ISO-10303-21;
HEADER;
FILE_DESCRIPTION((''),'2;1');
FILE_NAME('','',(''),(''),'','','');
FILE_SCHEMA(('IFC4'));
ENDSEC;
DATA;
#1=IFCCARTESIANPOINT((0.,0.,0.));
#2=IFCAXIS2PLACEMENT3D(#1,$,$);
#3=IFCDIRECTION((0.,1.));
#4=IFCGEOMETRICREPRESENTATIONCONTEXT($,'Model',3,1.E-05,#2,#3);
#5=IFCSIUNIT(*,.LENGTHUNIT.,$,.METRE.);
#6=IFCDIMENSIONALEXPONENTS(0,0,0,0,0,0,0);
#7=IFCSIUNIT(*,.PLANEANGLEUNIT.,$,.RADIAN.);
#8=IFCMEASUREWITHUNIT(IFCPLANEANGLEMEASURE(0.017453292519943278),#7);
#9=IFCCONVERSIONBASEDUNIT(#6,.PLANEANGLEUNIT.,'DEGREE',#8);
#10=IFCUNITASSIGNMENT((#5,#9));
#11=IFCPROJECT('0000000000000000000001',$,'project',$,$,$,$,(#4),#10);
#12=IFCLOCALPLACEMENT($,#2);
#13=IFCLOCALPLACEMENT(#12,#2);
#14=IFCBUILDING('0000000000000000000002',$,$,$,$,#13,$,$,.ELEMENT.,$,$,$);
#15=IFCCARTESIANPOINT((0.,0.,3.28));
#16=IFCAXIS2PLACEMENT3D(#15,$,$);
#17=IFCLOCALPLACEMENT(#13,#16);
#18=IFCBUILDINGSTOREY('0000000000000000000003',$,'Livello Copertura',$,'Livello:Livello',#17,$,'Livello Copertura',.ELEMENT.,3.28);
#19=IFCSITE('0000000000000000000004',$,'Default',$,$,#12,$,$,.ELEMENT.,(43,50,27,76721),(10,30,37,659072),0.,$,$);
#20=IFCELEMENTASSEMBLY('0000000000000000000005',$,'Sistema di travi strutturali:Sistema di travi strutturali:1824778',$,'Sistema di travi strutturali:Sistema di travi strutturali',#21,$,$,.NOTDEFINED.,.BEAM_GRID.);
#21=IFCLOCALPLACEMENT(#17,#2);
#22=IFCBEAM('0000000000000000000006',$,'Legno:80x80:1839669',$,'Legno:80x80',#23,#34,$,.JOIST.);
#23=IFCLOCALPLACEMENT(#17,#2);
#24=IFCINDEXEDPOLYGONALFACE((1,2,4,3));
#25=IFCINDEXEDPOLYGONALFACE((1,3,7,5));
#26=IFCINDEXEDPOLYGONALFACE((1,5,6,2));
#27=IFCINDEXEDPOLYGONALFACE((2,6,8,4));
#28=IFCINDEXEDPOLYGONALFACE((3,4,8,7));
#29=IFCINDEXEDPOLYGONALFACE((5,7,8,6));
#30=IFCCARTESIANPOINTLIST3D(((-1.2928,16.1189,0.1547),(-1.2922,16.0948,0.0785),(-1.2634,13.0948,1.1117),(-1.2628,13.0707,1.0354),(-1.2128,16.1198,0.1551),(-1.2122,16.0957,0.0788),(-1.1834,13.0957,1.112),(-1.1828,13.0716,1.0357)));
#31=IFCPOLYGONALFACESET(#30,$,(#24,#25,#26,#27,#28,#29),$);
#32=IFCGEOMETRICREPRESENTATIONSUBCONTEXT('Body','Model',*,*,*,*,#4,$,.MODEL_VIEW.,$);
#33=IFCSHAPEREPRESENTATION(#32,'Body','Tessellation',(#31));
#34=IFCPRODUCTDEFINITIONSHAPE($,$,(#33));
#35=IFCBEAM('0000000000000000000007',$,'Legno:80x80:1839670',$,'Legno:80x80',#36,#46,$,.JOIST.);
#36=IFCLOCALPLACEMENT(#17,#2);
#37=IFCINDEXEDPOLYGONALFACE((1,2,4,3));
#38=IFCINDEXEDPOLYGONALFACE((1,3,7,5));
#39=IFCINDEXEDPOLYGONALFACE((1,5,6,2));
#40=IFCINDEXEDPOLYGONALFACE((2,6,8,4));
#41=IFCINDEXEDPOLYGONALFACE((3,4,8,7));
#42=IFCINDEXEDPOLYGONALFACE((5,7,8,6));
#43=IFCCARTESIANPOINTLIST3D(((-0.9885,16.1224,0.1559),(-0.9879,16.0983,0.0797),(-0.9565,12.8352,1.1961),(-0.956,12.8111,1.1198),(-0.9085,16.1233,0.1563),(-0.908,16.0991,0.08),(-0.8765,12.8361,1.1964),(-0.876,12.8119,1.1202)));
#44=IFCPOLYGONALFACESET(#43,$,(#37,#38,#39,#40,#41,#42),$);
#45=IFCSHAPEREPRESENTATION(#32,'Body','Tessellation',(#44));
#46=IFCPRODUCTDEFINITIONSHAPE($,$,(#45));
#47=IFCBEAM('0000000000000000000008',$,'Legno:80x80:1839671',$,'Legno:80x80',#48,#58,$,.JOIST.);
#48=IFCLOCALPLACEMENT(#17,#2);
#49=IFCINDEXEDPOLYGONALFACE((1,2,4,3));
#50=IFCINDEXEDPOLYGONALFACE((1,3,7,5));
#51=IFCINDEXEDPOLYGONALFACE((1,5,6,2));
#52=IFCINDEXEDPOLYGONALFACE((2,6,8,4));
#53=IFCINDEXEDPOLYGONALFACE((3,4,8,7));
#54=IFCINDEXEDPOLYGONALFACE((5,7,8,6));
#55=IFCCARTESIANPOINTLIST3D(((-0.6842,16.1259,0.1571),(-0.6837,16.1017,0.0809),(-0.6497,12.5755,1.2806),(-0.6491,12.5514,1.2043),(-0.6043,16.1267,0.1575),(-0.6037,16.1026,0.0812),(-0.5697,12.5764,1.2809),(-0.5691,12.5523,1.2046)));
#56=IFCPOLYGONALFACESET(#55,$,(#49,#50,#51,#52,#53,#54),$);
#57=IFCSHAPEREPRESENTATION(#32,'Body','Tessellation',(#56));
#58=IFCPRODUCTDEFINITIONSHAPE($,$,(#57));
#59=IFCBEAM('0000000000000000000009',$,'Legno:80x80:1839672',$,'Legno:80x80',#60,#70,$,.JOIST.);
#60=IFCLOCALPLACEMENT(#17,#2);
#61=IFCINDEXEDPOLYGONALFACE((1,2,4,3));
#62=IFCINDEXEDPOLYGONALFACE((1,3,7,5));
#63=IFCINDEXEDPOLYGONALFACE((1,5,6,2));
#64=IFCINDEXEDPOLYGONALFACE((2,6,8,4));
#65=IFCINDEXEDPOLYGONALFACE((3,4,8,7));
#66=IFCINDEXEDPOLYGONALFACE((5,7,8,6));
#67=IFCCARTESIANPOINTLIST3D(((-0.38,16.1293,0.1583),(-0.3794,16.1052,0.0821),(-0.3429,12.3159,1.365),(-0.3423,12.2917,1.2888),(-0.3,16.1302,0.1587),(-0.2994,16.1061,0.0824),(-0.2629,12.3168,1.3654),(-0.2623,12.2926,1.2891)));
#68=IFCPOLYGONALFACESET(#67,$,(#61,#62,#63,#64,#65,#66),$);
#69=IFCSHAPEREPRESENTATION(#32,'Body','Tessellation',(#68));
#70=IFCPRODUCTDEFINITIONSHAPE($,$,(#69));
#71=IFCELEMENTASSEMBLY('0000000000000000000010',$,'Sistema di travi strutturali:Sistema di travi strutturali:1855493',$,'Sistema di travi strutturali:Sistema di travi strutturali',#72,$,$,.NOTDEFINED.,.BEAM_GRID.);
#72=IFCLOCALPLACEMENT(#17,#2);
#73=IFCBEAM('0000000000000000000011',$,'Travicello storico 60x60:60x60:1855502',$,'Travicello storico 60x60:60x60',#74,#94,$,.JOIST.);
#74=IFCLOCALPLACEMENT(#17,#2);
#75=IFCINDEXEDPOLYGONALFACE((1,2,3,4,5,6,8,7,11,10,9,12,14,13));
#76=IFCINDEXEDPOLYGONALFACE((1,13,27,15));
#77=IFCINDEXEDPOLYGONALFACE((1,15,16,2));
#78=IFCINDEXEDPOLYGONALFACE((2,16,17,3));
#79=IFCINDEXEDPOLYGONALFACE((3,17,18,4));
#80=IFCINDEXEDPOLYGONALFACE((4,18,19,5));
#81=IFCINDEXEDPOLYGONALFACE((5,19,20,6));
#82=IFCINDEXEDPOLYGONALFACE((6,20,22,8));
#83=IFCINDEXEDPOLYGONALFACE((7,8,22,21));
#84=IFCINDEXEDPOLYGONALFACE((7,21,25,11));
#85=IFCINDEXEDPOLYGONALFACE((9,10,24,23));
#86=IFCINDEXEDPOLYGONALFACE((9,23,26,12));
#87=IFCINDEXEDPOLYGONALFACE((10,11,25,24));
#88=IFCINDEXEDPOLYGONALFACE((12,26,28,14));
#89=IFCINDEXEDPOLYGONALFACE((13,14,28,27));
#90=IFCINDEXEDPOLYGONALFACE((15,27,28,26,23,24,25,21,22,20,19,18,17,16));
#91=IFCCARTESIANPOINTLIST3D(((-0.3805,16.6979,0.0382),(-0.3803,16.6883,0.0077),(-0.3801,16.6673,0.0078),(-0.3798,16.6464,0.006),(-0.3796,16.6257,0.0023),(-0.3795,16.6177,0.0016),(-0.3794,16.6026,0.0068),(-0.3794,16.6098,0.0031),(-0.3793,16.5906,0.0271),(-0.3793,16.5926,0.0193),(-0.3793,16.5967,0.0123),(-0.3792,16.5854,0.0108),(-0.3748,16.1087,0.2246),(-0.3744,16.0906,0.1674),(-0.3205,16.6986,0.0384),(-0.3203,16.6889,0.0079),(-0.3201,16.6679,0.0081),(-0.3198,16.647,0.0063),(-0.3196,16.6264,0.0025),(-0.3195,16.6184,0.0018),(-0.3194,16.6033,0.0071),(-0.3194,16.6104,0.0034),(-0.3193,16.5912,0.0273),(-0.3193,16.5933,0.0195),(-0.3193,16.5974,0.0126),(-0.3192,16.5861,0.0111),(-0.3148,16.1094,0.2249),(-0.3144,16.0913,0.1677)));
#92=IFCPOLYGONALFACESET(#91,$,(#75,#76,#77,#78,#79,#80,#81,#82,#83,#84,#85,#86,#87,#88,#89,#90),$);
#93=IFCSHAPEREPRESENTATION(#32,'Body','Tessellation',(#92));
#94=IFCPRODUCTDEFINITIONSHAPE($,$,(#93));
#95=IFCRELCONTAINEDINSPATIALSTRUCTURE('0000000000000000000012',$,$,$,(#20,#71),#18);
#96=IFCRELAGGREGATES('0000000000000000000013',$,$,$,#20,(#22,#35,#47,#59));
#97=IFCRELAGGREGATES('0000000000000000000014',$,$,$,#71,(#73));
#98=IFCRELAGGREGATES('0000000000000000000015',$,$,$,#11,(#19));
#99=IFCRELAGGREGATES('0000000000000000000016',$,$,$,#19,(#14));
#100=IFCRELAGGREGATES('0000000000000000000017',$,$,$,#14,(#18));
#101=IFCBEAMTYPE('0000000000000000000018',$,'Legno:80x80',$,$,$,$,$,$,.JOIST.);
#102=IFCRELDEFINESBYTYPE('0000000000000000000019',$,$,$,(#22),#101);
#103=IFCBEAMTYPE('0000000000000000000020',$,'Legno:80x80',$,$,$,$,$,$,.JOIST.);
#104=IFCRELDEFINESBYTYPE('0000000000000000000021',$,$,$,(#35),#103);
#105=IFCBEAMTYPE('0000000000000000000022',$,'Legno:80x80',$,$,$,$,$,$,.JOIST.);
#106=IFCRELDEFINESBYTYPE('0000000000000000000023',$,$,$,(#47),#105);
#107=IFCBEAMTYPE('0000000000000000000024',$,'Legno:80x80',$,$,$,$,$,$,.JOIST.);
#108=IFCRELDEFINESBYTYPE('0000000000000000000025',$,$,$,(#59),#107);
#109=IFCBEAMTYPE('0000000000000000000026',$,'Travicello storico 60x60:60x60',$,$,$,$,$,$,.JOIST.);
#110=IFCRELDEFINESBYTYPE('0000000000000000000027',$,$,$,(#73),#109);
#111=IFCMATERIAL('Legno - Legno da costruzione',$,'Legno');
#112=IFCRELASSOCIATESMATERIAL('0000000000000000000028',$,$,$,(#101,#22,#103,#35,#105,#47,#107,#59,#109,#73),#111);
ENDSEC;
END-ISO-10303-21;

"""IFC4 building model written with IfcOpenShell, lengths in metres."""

from ifc_helpers import new_model, entity, si_unit, converted_unit, direction, frame, origin, place, context, subcontext, project, spatial, line, arc, indexed_curve, outline, extrude, source, transform, mapped, material, type_object, type_shapes, element, aggregate, save


model = new_model("IFC4")

# Units and contexts
model_context = context("Model", 3, precision=1e-05, world=origin(), true_north=direction((0.0, 1.0)))
body_context = subcontext(model_context, "Body", "Model", "MODEL_VIEW")
ifc_project = project(units=[si_unit("LENGTHUNIT", "METRE"), converted_unit("PLANEANGLEUNIT", "DEGREE", entity("IfcPlaneAngleMeasure", 0.017453292519943278), si_unit("PLANEANGLEUNIT", "RADIAN"), dimensions=[0, 0, 0, 0, 0, 0, 0])], contexts=[model_context])

# Site, building, storey
site_placement = place(None, origin())
site = spatial("IfcSite", under=ifc_project, at=site_placement, Name="Default", CompositionType="ELEMENT", RefLatitude=(43, 50, 27, 76721), RefLongitude=(10, 30, 37, 659072), RefElevation=0.0)
building_placement = place(site_placement, origin())
building = spatial("IfcBuilding", under=site, at=building_placement, CompositionType="ELEMENT")
storey_placement = place(building_placement, frame((0.0, 0.0, 3.28)))
storey = spatial("IfcBuildingStorey", under=building, at=storey_placement, Name="Livello Copertura", ObjectType="Livello:Livello", LongName="Livello Copertura", CompositionType="ELEMENT", Elevation=3.28)

# Shared definitions
ifc_material = material(Name="Legno - Legno da costruzione", Category="Legno")

# Element assemblies, beams
assembly_1_placement = place(storey_placement, origin())
assembly_1 = element("IfcElementAssembly", 1, at=assembly_1_placement, inside=storey, Name="Sistema di travi strutturali:Sistema di travi strutturali:1824778", ObjectType="Sistema di travi strutturali:Sistema di travi strutturali", AssemblyPlace="NOTDEFINED", PredefinedType="BEAM_GRID")
beam_type_1 = type_object("IfcBeamType", Name="Legno:80x80", PredefinedType="JOIST", material=ifc_material)
shared_shape_1 = source(origin(), body_context, "Body", "SweptSolid", [
    extrude(outline(indexed_curve([(-1.586, -0.04), (1.586, -0.04), (1.586, 0.04), (-1.586, 0.04), (-1.586, -0.04)], self_intersect=False)), frame((0.0, 0.0, -0.04), z_axis=(0.0, 0.0, 1.0), x_axis=(-1.0, 0.0, 0.0)), (0.0, 0.0, 1.0), 0.08),
])
type_shapes(beam_type_1, [shared_shape_1])
beam_1_placement = place(assembly_1_placement, frame((-1.2378, 14.5953, 0.5952), z_axis=(-0.007187, 0.301619, 0.953402), x_axis=(0.009277, -0.953365, 0.301677)))
beam_1 = element("IfcBeam", 2, at=beam_1_placement, type_object=beam_type_1, material=ifc_material, Name="Legno:80x80:1839669", ObjectType="Legno:80x80", PredefinedType="JOIST", context=body_context, shape_type="MappedRepresentation", body=[
    mapped(shared_shape_1, transform((0.0, 0.0, 0.0), scale=1.0)),
])
beam_type_2 = type_object("IfcBeamType", Name="Legno:80x80", PredefinedType="JOIST", material=ifc_material)
shared_shape_2 = source(origin(), body_context, "Body", "SweptSolid", [
    extrude(outline(indexed_curve([(-1.724, -0.04), (1.724, -0.04), (1.724, 0.04), (-1.724, 0.04), (-1.724, -0.04)], self_intersect=False)), frame((0.0, 0.0, -0.04), z_axis=(0.0, 0.0, 1.0), x_axis=(-1.0, 0.0, 0.0)), (0.0, 0.0, 1.0), 0.08),
])
type_shapes(beam_type_2, [shared_shape_2])
beam_2_placement = place(assembly_1_placement, frame((-0.9322, 14.4672, 0.6381), z_axis=(-0.007187, 0.301619, 0.953402), x_axis=(0.009277, -0.953365, 0.301677)))
beam_2 = element("IfcBeam", 3, at=beam_2_placement, type_object=beam_type_2, material=ifc_material, Name="Legno:80x80:1839670", ObjectType="Legno:80x80", PredefinedType="JOIST", context=body_context, shape_type="MappedRepresentation", body=[
    mapped(shared_shape_2, transform((0.0, 0.0, 0.0), scale=1.0)),
])
beam_type_3 = type_object("IfcBeamType", Name="Legno:80x80", PredefinedType="JOIST", material=ifc_material)
shared_shape_3 = source(origin(), body_context, "Body", "SweptSolid", [
    extrude(outline(indexed_curve([(-1.862, -0.04), (1.862, -0.04), (1.862, 0.04), (-1.862, 0.04), (-1.862, -0.04)], self_intersect=False)), frame((0.0, 0.0, -0.04), z_axis=(0.0, 0.0, 1.0), x_axis=(-1.0, 0.0, 0.0)), (0.0, 0.0, 1.0), 0.08),
])
type_shapes(beam_type_3, [shared_shape_3])
beam_3_placement = place(assembly_1_placement, frame((-0.6267, 14.3391, 0.6809), z_axis=(-0.007187, 0.301619, 0.953402), x_axis=(0.009277, -0.953365, 0.301677)))
beam_3 = element("IfcBeam", 4, at=beam_3_placement, type_object=beam_type_3, material=ifc_material, Name="Legno:80x80:1839671", ObjectType="Legno:80x80", PredefinedType="JOIST", context=body_context, shape_type="MappedRepresentation", body=[
    mapped(shared_shape_3, transform((0.0, 0.0, 0.0), scale=1.0)),
])
beam_type_4 = type_object("IfcBeamType", Name="Legno:80x80", PredefinedType="JOIST", material=ifc_material)
shared_shape_4 = source(origin(), body_context, "Body", "SweptSolid", [
    extrude(outline(indexed_curve([(-2.0, -0.04), (2.0, -0.04), (2.0, 0.04), (-2.0, 0.04), (-2.0, -0.04)], self_intersect=False)), frame((0.0, 0.0, -0.04), z_axis=(0.0, 0.0, 1.0), x_axis=(-1.0, 0.0, 0.0)), (0.0, 0.0, 1.0), 0.08),
])
type_shapes(beam_type_4, [shared_shape_4])
beam_4_placement = place(assembly_1_placement, frame((-0.3211, 14.211, 0.7237), z_axis=(-0.007187, 0.301619, 0.953402), x_axis=(0.009277, -0.953365, 0.301677)))
beam_4 = element("IfcBeam", 5, at=beam_4_placement, type_object=beam_type_4, material=ifc_material, Name="Legno:80x80:1839672", ObjectType="Legno:80x80", PredefinedType="JOIST", context=body_context, shape_type="MappedRepresentation", body=[
    mapped(shared_shape_4, transform((0.0, 0.0, 0.0), scale=1.0)),
])
aggregate(assembly_1, [beam_1, beam_2, beam_3, beam_4])
assembly_2_placement = place(storey_placement, origin())
assembly_2 = element("IfcElementAssembly", 6, at=assembly_2_placement, inside=storey, Name="Sistema di travi strutturali:Sistema di travi strutturali:1855493", ObjectType="Sistema di travi strutturali:Sistema di travi strutturali", AssemblyPlace="NOTDEFINED", PredefinedType="BEAM_GRID")
beam_type_5 = type_object("IfcBeamType", Name="Travicello storico 60x60:60x60", PredefinedType="JOIST", material=ifc_material)
shared_shape_5 = source(origin(), body_context, "Body", "SweptSolid", [
    extrude(outline(indexed_curve([(-0.0359, -0.4049), (0.0241, -0.4049), (0.0241, 0.1141), (0.0071, 0.1141), (0.0228, 0.1317), (0.0201, 0.1551), (0.0061, 0.1833), (-0.0039, 0.2131), (-0.0359, 0.2131)], segments=[line(1, 2, 3, 4), arc(4, 5, 6), arc(6, 7, 8), line(8, 9, 1)], self_intersect=False)), frame((0.0441, -0.03, -0.0059), z_axis=(0.0, 1.0, 0.0), x_axis=(0.0, 0.0, -1.0)), (0.0, 0.0, 1.0), 0.06),
])
type_shapes(beam_type_5, [shared_shape_5])
beam_5_placement = place(assembly_2_placement, frame((-0.3488, 16.5281, 0.0607), z_axis=(-0.007187, 0.301619, 0.953402), x_axis=(0.009277, -0.953365, 0.301677)))
beam_5 = element("IfcBeam", 7, at=beam_5_placement, type_object=beam_type_5, material=ifc_material, Name="Travicello storico 60x60:60x60:1855502", ObjectType="Travicello storico 60x60:60x60", PredefinedType="JOIST", context=body_context, shape_type="MappedRepresentation", body=[
    mapped(shared_shape_5, transform((0.0, 0.0, 0.0), scale=1.0)),
])
aggregate(assembly_2, [beam_5])

save(model, "model.ifc")
